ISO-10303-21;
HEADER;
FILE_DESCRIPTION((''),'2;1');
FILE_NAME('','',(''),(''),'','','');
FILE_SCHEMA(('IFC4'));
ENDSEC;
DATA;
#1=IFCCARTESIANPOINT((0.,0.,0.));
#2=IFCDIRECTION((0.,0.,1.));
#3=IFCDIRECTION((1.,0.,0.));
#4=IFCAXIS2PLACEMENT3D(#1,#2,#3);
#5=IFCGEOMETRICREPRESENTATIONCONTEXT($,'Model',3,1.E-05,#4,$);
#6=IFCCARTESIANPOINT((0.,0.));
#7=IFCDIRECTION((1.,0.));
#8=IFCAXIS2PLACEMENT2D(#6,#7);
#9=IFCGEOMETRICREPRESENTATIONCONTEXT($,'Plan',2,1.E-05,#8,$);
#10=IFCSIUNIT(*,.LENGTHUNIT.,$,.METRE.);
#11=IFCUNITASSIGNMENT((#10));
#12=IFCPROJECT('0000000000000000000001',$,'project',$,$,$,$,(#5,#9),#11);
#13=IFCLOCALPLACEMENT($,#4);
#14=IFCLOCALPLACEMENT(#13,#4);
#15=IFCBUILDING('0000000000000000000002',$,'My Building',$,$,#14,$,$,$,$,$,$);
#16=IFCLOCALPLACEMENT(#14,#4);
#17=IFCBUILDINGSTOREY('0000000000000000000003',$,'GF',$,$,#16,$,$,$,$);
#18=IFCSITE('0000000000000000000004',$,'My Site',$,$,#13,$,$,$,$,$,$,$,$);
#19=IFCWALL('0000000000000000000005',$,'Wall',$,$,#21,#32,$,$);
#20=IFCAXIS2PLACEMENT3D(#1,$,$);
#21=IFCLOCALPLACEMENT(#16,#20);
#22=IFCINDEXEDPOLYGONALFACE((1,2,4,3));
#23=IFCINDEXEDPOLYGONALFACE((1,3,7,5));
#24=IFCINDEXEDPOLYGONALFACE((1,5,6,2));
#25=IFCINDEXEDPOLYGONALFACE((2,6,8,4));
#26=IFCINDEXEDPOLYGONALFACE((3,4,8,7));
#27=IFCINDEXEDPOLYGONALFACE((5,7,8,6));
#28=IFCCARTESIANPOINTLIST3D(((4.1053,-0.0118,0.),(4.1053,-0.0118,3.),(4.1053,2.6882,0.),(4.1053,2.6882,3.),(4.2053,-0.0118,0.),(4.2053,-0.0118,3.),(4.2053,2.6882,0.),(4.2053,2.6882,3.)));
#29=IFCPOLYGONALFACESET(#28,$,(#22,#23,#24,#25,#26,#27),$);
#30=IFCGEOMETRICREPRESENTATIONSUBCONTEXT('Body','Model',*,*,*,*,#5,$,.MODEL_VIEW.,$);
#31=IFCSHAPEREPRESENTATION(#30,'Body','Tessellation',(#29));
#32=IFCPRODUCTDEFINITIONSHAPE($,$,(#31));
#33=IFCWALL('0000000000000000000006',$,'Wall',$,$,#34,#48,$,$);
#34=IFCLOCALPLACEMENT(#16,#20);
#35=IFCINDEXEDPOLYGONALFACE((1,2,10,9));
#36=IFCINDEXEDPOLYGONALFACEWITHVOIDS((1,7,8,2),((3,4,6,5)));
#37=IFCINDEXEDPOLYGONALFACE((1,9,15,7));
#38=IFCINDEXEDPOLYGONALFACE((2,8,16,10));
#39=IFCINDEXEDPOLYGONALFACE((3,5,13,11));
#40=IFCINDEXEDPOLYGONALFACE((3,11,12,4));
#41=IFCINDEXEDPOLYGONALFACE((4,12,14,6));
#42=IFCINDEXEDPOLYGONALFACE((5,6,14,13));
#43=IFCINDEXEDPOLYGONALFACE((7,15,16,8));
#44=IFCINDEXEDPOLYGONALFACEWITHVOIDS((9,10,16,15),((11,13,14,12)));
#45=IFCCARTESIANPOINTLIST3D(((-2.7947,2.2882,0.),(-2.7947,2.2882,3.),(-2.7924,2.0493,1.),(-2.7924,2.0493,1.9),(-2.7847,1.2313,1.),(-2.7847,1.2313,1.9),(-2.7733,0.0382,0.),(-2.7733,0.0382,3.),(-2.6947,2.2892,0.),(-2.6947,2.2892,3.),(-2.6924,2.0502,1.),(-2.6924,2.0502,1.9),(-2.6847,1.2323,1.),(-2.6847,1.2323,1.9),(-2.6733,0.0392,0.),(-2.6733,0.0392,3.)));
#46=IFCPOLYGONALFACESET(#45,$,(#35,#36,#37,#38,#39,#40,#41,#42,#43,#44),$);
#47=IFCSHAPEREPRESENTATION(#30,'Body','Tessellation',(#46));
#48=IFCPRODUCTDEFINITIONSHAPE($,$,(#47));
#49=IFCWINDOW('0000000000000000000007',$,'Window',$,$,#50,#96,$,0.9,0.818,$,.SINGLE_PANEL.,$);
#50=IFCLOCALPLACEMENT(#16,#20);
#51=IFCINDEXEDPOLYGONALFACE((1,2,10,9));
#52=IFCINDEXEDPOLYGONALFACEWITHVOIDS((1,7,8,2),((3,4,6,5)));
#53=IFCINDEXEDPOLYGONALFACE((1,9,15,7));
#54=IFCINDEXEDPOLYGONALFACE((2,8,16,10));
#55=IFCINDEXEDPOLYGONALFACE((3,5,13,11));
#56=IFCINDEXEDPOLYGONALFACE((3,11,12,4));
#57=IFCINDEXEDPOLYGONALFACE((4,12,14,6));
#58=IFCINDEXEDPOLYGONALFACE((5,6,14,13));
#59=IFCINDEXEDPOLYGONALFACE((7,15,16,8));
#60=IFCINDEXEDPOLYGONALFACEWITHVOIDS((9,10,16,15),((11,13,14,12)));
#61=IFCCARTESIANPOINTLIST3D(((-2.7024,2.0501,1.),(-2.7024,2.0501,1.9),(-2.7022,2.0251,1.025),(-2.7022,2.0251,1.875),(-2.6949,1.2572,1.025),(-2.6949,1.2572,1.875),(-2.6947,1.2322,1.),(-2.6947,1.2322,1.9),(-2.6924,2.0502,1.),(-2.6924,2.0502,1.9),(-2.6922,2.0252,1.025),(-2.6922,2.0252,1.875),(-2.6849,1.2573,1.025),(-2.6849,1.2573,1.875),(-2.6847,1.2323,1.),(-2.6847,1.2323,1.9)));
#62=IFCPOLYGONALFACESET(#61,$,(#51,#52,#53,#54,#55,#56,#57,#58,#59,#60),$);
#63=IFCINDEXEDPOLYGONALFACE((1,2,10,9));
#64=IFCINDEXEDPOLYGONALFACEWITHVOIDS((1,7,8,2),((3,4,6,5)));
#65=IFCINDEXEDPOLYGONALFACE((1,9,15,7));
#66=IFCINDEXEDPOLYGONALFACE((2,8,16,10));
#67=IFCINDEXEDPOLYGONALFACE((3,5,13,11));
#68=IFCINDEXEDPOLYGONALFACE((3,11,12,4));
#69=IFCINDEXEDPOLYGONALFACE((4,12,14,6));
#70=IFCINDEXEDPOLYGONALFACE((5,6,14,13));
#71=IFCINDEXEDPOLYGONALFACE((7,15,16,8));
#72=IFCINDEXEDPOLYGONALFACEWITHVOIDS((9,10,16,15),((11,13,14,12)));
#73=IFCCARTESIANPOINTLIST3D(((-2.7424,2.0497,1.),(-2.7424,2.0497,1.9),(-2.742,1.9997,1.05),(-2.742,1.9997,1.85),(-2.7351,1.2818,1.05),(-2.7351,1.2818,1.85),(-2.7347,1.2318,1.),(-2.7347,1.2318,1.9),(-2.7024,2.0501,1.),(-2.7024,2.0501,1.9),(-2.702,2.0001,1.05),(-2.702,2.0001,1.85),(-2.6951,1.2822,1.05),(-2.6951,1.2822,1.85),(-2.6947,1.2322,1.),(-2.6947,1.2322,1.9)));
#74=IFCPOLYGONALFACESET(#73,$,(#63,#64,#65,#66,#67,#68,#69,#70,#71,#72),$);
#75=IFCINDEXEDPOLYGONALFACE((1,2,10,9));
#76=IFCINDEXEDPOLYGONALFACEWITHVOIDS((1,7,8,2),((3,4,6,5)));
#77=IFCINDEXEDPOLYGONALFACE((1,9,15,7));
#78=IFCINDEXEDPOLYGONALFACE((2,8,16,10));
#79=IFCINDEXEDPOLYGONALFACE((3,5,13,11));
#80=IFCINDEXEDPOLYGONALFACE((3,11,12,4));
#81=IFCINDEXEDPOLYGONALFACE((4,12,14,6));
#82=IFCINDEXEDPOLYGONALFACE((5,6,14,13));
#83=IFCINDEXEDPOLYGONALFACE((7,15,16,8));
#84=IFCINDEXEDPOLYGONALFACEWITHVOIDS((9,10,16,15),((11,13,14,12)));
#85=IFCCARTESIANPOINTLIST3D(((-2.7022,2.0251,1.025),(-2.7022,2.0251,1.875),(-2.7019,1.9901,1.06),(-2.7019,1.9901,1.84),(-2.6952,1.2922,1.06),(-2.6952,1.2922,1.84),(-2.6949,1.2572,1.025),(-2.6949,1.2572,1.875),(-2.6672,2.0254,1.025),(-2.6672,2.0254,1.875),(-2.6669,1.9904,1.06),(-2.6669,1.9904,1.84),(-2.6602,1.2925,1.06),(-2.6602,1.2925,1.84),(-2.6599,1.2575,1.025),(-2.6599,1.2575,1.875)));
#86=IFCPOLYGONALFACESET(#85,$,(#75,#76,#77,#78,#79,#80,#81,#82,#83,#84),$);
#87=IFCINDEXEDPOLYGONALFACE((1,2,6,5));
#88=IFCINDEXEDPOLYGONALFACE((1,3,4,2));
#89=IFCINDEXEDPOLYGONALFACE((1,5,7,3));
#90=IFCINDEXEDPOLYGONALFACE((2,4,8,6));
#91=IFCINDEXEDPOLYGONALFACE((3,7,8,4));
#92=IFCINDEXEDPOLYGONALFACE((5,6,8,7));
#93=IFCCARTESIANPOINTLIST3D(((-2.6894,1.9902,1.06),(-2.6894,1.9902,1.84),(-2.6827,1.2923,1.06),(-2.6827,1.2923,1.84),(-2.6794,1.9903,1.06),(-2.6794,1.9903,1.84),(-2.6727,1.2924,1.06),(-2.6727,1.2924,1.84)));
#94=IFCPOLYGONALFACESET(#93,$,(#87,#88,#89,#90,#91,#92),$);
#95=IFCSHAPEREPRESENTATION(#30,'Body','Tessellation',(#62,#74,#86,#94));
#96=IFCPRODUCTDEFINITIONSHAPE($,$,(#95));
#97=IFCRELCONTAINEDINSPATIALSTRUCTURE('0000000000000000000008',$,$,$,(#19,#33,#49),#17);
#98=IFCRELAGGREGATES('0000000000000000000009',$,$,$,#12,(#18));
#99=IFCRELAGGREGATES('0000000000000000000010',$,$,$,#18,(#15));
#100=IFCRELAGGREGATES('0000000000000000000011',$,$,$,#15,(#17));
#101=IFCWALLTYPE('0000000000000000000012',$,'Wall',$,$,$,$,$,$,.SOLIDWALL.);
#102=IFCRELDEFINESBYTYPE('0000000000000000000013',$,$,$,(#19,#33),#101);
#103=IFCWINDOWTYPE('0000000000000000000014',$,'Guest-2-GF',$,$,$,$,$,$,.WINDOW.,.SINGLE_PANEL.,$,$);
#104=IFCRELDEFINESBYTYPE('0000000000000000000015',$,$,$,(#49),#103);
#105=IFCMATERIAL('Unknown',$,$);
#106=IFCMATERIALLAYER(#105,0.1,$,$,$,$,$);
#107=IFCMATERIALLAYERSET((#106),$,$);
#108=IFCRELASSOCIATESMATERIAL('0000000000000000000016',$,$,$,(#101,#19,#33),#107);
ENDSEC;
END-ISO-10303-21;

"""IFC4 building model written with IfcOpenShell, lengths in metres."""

from ifc_helpers import new_model, entity, si_unit, frame, origin_with_axes, origin_2d_with_axis, place, context, subcontext, project, spatial, line, indexed_curve, outline, extrude, shape, source, transform, mapped, material, layer, layer_set, layer_usage, type_object, type_shapes, element, fill, save


model = new_model("IFC4")

# Units and contexts
model_context = context("Model", 3, precision=1e-05, world=origin_with_axes())
plan_context = context("Plan", 2, precision=1e-05, world=origin_2d_with_axis())
body_context_1 = subcontext(model_context, "Body", "Model", "MODEL_VIEW")
body_context_2 = subcontext(plan_context, "Body", "Plan", "PLAN_VIEW")
ifc_project = project(units=[si_unit("LENGTHUNIT", "METRE")], contexts=[model_context, plan_context])

# Site, building, storey
site_placement = place(None, origin_with_axes())
site = spatial("IfcSite", under=ifc_project, at=site_placement, Name="My Site")
building_placement = place(site_placement, origin_with_axes())
building = spatial("IfcBuilding", under=site, at=building_placement, Name="My Building")
storey_placement = place(building_placement, origin_with_axes())
storey = spatial("IfcBuildingStorey", under=building, at=storey_placement, Name="GF")

# Shared definitions
ifc_material = material(Name="Unknown")

# Shared definitions
ifc_layer_1 = layer(ifc_material, 0.1)
ifc_layer_set_1 = layer_set([ifc_layer_1])
wall_type = type_object("IfcWallType", Name="Wall", PredefinedType="SOLIDWALL", material=ifc_layer_set_1)

# Wall
ifc_layer_usage_1 = layer_usage(ifc_layer_set_1, "AXIS2", "POSITIVE", 0.0)
wall_1_placement = place(storey_placement, frame((4.2053, -0.0118, 0.0), z_axis=(0.0, 0.0, 1.0), x_axis=(0.0, 1.0, 0.0)))
element("IfcWall", 1, at=wall_1_placement, inside=storey, type_object=wall_type, material=ifc_layer_usage_1, Name="Wall", context=body_context_1, shape_type="SweptSolid", body=[
    extrude(outline(indexed_curve([(0.0, 0.0), (0.0, 0.1), (2.7, 0.1), (2.7, 0.0)], segments=[line(1, 2, 3, 4, 1)])), origin_with_axes(), (0.0, 0.0, 1.0), 3.0),
])

# Wall, opening, window
ifc_layer_usage_2 = layer_usage(ifc_layer_set_1, "AXIS2", "POSITIVE", 0.0)
wall_2_placement = place(storey_placement, frame((-2.7947, 2.2882, 0.0), z_axis=(0.0, 0.0, 1.0), x_axis=(0.009494, -0.999955, 0.0)))
wall_2 = element("IfcWall", 2, at=wall_2_placement, inside=storey, type_object=wall_type, material=ifc_layer_usage_2, Name="Wall", context=body_context_1, shape_type="SweptSolid", body=[
    extrude(outline(indexed_curve([(0.0, 0.0), (0.0, 0.1), (2.2501, 0.1), (2.2501, 0.0)], segments=[line(1, 2, 3, 4, 1)])), origin_with_axes(), (0.0, 0.0, 1.0), 3.0),
])
shared_shape_1 = source(origin_with_axes(), body_context_1, "Body", "SweptSolid", [
    extrude(outline(indexed_curve([(0.0, 0.0), (0.818, 0.0), (0.818, 0.9), (0.0, 0.9)], segments=[line(1, 2, 3, 4, 1)])), frame((0.0, -0.6, 0.0), z_axis=(0.0, -1.0, 0.0), x_axis=(1.0, 0.0, 0.0)), (0.0, 0.0, -1.0), 1.2),
])
opening_1_placement = place(wall_2_placement, frame((0.239, 0.0, 1.0), z_axis=(0.0, 0.0, 1.0), x_axis=(1.0, 0.0, 0.0)))
opening_1 = element("IfcOpeningElement", 3, at=opening_1_placement, cuts=wall_2, PredefinedType="OPENING", context=body_context_1, shape_type="MappedRepresentation", body=[
    mapped(shared_shape_1, transform((0.0, 0.0, 0.0), x_axis=(1.0, 0.0, 0.0), y_axis=(0.0, 1.0, 0.0), z_axis=(0.0, 0.0, 1.0), scale=1.0)),
])
window_type_1 = type_object("IfcWindowType", Name="Guest-2-GF", PartitioningType="SINGLE_PANEL", PredefinedType="WINDOW")
shared_shape_2 = source(origin_with_axes(), body_context_1, "Body", "SweptSolid", [
    extrude(outline(indexed_curve([(0.0, 0.0), (0.818, 0.0), (0.818, 0.9), (0.0, 0.9)], segments=[line(1, 2, 3, 4, 1)]), holes=[indexed_curve([(0.025, 0.025), (0.793, 0.025), (0.793, 0.875), (0.025, 0.875)], segments=[line(1, 2, 3, 4, 1)])]), frame((0.0, 0.09, 0.0), z_axis=(0.0, -1.0, 0.0), x_axis=(1.0, 0.0, 0.0)), (0.0, 0.0, -1.0), 0.01),
    extrude(outline(indexed_curve([(0.0, 0.0), (0.818, 0.0), (0.818, 0.9), (0.0, 0.9)], segments=[line(1, 2, 3, 4, 1)]), holes=[indexed_curve([(0.05, 0.05), (0.768, 0.05), (0.768, 0.85), (0.05, 0.85)], segments=[line(1, 2, 3, 4, 1)])]), frame((0.0, 0.05, 0.0), z_axis=(0.0, -1.0, 0.0), x_axis=(1.0, 0.0, 0.0)), (0.0, 0.0, -1.0), 0.04),
    extrude(outline(indexed_curve([(0.0, 0.0), (0.768, 0.0), (0.768, 0.85), (0.0, 0.85)], segments=[line(1, 2, 3, 4, 1)]), holes=[indexed_curve([(0.035, 0.035), (0.733, 0.035), (0.733, 0.815), (0.035, 0.815)], segments=[line(1, 2, 3, 4, 1)])]), frame((0.025, 0.09, 0.025), z_axis=(0.0, -1.0, 0.0), x_axis=(1.0, 0.0, 0.0)), (0.0, 0.0, -1.0), 0.035),
    extrude(outline(indexed_curve([(0.035, 0.035), (0.733, 0.035), (0.733, 0.815), (0.035, 0.815)], segments=[line(1, 2, 3, 4, 1)])), frame((0.025, 0.1025, 0.025), z_axis=(0.0, -1.0, 0.0), x_axis=(1.0, 0.0, 0.0)), (0.0, 0.0, -1.0), 0.01),
])
shared_shape_3 = source(origin_with_axes(), body_context_2, "Body", "Curve2D", [
    entity("IfcIndexedPolyCurve", entity("IfcCartesianPointList2D", [[0.05, 0.05], [0.768, 0.05]])),
    entity("IfcIndexedPolyCurve", entity("IfcCartesianPointList2D", [[0.0, 0.1], [0.025, 0.1], [0.025, 0.09], [0.05, 0.09], [0.05, 0.05], [0.0, 0.05]]), [entity("IfcLineIndex", [1, 2, 3, 4, 5, 6, 1])]),
    entity("IfcIndexedPolyCurve", entity("IfcCartesianPointList2D", [[0.818, 0.1], [0.793, 0.1], [0.793, 0.09], [0.768, 0.09], [0.768, 0.05], [0.818, 0.05]]), [entity("IfcLineIndex", [1, 2, 3, 4, 5, 6, 1])]),
    entity("IfcIndexedPolyCurve", entity("IfcCartesianPointList2D", [[0.025, 0.09], [0.06, 0.09], [0.06, 0.125], [0.025, 0.125]]), [entity("IfcLineIndex", [1, 2, 3, 4, 1])]),
    entity("IfcIndexedPolyCurve", entity("IfcCartesianPointList2D", [[0.793, 0.09], [0.758, 0.09], [0.758, 0.125], [0.793, 0.125]]), [entity("IfcLineIndex", [1, 2, 3, 4, 1])]),
    entity("IfcIndexedPolyCurve", entity("IfcCartesianPointList2D", [[0.06, 0.09], [0.758, 0.09]])),
    entity("IfcIndexedPolyCurve", entity("IfcCartesianPointList2D", [[0.06, 0.125], [0.758, 0.125]])),
    entity("IfcIndexedPolyCurve", entity("IfcCartesianPointList2D", [[0.06, 0.1075], [0.758, 0.1075]])),
])
type_shapes(window_type_1, [shared_shape_2, shared_shape_3])
window_1_placement = place(opening_1_placement, frame((0.0, 0.0, 0.0), z_axis=(0.0, 0.0, 1.0), x_axis=(1.0, 0.0, 0.0)))
window_1 = element("IfcWindow", 4, at=window_1_placement, inside=storey, type_object=window_type_1, Name="Window", OverallHeight=0.9, OverallWidth=0.818, PartitioningType="SINGLE_PANEL", shapes=[
    shape(body_context_1, "Body", "MappedRepresentation", [mapped(shared_shape_2, transform((0.0, 0.0, 0.0), x_axis=(1.0, 0.0, 0.0), y_axis=(0.0, 1.0, 0.0), z_axis=(0.0, 0.0, 1.0), scale=1.0))]),
    shape(body_context_2, "Body", "MappedRepresentation", [mapped(shared_shape_3, transform((0.0, 0.0, 0.0), x_axis=(1.0, 0.0, 0.0), y_axis=(0.0, 1.0, 0.0), z_axis=(0.0, 0.0, 1.0), scale=1.0))]),
])
fill(opening_1, window_1)

save(model, "model.ifc")
